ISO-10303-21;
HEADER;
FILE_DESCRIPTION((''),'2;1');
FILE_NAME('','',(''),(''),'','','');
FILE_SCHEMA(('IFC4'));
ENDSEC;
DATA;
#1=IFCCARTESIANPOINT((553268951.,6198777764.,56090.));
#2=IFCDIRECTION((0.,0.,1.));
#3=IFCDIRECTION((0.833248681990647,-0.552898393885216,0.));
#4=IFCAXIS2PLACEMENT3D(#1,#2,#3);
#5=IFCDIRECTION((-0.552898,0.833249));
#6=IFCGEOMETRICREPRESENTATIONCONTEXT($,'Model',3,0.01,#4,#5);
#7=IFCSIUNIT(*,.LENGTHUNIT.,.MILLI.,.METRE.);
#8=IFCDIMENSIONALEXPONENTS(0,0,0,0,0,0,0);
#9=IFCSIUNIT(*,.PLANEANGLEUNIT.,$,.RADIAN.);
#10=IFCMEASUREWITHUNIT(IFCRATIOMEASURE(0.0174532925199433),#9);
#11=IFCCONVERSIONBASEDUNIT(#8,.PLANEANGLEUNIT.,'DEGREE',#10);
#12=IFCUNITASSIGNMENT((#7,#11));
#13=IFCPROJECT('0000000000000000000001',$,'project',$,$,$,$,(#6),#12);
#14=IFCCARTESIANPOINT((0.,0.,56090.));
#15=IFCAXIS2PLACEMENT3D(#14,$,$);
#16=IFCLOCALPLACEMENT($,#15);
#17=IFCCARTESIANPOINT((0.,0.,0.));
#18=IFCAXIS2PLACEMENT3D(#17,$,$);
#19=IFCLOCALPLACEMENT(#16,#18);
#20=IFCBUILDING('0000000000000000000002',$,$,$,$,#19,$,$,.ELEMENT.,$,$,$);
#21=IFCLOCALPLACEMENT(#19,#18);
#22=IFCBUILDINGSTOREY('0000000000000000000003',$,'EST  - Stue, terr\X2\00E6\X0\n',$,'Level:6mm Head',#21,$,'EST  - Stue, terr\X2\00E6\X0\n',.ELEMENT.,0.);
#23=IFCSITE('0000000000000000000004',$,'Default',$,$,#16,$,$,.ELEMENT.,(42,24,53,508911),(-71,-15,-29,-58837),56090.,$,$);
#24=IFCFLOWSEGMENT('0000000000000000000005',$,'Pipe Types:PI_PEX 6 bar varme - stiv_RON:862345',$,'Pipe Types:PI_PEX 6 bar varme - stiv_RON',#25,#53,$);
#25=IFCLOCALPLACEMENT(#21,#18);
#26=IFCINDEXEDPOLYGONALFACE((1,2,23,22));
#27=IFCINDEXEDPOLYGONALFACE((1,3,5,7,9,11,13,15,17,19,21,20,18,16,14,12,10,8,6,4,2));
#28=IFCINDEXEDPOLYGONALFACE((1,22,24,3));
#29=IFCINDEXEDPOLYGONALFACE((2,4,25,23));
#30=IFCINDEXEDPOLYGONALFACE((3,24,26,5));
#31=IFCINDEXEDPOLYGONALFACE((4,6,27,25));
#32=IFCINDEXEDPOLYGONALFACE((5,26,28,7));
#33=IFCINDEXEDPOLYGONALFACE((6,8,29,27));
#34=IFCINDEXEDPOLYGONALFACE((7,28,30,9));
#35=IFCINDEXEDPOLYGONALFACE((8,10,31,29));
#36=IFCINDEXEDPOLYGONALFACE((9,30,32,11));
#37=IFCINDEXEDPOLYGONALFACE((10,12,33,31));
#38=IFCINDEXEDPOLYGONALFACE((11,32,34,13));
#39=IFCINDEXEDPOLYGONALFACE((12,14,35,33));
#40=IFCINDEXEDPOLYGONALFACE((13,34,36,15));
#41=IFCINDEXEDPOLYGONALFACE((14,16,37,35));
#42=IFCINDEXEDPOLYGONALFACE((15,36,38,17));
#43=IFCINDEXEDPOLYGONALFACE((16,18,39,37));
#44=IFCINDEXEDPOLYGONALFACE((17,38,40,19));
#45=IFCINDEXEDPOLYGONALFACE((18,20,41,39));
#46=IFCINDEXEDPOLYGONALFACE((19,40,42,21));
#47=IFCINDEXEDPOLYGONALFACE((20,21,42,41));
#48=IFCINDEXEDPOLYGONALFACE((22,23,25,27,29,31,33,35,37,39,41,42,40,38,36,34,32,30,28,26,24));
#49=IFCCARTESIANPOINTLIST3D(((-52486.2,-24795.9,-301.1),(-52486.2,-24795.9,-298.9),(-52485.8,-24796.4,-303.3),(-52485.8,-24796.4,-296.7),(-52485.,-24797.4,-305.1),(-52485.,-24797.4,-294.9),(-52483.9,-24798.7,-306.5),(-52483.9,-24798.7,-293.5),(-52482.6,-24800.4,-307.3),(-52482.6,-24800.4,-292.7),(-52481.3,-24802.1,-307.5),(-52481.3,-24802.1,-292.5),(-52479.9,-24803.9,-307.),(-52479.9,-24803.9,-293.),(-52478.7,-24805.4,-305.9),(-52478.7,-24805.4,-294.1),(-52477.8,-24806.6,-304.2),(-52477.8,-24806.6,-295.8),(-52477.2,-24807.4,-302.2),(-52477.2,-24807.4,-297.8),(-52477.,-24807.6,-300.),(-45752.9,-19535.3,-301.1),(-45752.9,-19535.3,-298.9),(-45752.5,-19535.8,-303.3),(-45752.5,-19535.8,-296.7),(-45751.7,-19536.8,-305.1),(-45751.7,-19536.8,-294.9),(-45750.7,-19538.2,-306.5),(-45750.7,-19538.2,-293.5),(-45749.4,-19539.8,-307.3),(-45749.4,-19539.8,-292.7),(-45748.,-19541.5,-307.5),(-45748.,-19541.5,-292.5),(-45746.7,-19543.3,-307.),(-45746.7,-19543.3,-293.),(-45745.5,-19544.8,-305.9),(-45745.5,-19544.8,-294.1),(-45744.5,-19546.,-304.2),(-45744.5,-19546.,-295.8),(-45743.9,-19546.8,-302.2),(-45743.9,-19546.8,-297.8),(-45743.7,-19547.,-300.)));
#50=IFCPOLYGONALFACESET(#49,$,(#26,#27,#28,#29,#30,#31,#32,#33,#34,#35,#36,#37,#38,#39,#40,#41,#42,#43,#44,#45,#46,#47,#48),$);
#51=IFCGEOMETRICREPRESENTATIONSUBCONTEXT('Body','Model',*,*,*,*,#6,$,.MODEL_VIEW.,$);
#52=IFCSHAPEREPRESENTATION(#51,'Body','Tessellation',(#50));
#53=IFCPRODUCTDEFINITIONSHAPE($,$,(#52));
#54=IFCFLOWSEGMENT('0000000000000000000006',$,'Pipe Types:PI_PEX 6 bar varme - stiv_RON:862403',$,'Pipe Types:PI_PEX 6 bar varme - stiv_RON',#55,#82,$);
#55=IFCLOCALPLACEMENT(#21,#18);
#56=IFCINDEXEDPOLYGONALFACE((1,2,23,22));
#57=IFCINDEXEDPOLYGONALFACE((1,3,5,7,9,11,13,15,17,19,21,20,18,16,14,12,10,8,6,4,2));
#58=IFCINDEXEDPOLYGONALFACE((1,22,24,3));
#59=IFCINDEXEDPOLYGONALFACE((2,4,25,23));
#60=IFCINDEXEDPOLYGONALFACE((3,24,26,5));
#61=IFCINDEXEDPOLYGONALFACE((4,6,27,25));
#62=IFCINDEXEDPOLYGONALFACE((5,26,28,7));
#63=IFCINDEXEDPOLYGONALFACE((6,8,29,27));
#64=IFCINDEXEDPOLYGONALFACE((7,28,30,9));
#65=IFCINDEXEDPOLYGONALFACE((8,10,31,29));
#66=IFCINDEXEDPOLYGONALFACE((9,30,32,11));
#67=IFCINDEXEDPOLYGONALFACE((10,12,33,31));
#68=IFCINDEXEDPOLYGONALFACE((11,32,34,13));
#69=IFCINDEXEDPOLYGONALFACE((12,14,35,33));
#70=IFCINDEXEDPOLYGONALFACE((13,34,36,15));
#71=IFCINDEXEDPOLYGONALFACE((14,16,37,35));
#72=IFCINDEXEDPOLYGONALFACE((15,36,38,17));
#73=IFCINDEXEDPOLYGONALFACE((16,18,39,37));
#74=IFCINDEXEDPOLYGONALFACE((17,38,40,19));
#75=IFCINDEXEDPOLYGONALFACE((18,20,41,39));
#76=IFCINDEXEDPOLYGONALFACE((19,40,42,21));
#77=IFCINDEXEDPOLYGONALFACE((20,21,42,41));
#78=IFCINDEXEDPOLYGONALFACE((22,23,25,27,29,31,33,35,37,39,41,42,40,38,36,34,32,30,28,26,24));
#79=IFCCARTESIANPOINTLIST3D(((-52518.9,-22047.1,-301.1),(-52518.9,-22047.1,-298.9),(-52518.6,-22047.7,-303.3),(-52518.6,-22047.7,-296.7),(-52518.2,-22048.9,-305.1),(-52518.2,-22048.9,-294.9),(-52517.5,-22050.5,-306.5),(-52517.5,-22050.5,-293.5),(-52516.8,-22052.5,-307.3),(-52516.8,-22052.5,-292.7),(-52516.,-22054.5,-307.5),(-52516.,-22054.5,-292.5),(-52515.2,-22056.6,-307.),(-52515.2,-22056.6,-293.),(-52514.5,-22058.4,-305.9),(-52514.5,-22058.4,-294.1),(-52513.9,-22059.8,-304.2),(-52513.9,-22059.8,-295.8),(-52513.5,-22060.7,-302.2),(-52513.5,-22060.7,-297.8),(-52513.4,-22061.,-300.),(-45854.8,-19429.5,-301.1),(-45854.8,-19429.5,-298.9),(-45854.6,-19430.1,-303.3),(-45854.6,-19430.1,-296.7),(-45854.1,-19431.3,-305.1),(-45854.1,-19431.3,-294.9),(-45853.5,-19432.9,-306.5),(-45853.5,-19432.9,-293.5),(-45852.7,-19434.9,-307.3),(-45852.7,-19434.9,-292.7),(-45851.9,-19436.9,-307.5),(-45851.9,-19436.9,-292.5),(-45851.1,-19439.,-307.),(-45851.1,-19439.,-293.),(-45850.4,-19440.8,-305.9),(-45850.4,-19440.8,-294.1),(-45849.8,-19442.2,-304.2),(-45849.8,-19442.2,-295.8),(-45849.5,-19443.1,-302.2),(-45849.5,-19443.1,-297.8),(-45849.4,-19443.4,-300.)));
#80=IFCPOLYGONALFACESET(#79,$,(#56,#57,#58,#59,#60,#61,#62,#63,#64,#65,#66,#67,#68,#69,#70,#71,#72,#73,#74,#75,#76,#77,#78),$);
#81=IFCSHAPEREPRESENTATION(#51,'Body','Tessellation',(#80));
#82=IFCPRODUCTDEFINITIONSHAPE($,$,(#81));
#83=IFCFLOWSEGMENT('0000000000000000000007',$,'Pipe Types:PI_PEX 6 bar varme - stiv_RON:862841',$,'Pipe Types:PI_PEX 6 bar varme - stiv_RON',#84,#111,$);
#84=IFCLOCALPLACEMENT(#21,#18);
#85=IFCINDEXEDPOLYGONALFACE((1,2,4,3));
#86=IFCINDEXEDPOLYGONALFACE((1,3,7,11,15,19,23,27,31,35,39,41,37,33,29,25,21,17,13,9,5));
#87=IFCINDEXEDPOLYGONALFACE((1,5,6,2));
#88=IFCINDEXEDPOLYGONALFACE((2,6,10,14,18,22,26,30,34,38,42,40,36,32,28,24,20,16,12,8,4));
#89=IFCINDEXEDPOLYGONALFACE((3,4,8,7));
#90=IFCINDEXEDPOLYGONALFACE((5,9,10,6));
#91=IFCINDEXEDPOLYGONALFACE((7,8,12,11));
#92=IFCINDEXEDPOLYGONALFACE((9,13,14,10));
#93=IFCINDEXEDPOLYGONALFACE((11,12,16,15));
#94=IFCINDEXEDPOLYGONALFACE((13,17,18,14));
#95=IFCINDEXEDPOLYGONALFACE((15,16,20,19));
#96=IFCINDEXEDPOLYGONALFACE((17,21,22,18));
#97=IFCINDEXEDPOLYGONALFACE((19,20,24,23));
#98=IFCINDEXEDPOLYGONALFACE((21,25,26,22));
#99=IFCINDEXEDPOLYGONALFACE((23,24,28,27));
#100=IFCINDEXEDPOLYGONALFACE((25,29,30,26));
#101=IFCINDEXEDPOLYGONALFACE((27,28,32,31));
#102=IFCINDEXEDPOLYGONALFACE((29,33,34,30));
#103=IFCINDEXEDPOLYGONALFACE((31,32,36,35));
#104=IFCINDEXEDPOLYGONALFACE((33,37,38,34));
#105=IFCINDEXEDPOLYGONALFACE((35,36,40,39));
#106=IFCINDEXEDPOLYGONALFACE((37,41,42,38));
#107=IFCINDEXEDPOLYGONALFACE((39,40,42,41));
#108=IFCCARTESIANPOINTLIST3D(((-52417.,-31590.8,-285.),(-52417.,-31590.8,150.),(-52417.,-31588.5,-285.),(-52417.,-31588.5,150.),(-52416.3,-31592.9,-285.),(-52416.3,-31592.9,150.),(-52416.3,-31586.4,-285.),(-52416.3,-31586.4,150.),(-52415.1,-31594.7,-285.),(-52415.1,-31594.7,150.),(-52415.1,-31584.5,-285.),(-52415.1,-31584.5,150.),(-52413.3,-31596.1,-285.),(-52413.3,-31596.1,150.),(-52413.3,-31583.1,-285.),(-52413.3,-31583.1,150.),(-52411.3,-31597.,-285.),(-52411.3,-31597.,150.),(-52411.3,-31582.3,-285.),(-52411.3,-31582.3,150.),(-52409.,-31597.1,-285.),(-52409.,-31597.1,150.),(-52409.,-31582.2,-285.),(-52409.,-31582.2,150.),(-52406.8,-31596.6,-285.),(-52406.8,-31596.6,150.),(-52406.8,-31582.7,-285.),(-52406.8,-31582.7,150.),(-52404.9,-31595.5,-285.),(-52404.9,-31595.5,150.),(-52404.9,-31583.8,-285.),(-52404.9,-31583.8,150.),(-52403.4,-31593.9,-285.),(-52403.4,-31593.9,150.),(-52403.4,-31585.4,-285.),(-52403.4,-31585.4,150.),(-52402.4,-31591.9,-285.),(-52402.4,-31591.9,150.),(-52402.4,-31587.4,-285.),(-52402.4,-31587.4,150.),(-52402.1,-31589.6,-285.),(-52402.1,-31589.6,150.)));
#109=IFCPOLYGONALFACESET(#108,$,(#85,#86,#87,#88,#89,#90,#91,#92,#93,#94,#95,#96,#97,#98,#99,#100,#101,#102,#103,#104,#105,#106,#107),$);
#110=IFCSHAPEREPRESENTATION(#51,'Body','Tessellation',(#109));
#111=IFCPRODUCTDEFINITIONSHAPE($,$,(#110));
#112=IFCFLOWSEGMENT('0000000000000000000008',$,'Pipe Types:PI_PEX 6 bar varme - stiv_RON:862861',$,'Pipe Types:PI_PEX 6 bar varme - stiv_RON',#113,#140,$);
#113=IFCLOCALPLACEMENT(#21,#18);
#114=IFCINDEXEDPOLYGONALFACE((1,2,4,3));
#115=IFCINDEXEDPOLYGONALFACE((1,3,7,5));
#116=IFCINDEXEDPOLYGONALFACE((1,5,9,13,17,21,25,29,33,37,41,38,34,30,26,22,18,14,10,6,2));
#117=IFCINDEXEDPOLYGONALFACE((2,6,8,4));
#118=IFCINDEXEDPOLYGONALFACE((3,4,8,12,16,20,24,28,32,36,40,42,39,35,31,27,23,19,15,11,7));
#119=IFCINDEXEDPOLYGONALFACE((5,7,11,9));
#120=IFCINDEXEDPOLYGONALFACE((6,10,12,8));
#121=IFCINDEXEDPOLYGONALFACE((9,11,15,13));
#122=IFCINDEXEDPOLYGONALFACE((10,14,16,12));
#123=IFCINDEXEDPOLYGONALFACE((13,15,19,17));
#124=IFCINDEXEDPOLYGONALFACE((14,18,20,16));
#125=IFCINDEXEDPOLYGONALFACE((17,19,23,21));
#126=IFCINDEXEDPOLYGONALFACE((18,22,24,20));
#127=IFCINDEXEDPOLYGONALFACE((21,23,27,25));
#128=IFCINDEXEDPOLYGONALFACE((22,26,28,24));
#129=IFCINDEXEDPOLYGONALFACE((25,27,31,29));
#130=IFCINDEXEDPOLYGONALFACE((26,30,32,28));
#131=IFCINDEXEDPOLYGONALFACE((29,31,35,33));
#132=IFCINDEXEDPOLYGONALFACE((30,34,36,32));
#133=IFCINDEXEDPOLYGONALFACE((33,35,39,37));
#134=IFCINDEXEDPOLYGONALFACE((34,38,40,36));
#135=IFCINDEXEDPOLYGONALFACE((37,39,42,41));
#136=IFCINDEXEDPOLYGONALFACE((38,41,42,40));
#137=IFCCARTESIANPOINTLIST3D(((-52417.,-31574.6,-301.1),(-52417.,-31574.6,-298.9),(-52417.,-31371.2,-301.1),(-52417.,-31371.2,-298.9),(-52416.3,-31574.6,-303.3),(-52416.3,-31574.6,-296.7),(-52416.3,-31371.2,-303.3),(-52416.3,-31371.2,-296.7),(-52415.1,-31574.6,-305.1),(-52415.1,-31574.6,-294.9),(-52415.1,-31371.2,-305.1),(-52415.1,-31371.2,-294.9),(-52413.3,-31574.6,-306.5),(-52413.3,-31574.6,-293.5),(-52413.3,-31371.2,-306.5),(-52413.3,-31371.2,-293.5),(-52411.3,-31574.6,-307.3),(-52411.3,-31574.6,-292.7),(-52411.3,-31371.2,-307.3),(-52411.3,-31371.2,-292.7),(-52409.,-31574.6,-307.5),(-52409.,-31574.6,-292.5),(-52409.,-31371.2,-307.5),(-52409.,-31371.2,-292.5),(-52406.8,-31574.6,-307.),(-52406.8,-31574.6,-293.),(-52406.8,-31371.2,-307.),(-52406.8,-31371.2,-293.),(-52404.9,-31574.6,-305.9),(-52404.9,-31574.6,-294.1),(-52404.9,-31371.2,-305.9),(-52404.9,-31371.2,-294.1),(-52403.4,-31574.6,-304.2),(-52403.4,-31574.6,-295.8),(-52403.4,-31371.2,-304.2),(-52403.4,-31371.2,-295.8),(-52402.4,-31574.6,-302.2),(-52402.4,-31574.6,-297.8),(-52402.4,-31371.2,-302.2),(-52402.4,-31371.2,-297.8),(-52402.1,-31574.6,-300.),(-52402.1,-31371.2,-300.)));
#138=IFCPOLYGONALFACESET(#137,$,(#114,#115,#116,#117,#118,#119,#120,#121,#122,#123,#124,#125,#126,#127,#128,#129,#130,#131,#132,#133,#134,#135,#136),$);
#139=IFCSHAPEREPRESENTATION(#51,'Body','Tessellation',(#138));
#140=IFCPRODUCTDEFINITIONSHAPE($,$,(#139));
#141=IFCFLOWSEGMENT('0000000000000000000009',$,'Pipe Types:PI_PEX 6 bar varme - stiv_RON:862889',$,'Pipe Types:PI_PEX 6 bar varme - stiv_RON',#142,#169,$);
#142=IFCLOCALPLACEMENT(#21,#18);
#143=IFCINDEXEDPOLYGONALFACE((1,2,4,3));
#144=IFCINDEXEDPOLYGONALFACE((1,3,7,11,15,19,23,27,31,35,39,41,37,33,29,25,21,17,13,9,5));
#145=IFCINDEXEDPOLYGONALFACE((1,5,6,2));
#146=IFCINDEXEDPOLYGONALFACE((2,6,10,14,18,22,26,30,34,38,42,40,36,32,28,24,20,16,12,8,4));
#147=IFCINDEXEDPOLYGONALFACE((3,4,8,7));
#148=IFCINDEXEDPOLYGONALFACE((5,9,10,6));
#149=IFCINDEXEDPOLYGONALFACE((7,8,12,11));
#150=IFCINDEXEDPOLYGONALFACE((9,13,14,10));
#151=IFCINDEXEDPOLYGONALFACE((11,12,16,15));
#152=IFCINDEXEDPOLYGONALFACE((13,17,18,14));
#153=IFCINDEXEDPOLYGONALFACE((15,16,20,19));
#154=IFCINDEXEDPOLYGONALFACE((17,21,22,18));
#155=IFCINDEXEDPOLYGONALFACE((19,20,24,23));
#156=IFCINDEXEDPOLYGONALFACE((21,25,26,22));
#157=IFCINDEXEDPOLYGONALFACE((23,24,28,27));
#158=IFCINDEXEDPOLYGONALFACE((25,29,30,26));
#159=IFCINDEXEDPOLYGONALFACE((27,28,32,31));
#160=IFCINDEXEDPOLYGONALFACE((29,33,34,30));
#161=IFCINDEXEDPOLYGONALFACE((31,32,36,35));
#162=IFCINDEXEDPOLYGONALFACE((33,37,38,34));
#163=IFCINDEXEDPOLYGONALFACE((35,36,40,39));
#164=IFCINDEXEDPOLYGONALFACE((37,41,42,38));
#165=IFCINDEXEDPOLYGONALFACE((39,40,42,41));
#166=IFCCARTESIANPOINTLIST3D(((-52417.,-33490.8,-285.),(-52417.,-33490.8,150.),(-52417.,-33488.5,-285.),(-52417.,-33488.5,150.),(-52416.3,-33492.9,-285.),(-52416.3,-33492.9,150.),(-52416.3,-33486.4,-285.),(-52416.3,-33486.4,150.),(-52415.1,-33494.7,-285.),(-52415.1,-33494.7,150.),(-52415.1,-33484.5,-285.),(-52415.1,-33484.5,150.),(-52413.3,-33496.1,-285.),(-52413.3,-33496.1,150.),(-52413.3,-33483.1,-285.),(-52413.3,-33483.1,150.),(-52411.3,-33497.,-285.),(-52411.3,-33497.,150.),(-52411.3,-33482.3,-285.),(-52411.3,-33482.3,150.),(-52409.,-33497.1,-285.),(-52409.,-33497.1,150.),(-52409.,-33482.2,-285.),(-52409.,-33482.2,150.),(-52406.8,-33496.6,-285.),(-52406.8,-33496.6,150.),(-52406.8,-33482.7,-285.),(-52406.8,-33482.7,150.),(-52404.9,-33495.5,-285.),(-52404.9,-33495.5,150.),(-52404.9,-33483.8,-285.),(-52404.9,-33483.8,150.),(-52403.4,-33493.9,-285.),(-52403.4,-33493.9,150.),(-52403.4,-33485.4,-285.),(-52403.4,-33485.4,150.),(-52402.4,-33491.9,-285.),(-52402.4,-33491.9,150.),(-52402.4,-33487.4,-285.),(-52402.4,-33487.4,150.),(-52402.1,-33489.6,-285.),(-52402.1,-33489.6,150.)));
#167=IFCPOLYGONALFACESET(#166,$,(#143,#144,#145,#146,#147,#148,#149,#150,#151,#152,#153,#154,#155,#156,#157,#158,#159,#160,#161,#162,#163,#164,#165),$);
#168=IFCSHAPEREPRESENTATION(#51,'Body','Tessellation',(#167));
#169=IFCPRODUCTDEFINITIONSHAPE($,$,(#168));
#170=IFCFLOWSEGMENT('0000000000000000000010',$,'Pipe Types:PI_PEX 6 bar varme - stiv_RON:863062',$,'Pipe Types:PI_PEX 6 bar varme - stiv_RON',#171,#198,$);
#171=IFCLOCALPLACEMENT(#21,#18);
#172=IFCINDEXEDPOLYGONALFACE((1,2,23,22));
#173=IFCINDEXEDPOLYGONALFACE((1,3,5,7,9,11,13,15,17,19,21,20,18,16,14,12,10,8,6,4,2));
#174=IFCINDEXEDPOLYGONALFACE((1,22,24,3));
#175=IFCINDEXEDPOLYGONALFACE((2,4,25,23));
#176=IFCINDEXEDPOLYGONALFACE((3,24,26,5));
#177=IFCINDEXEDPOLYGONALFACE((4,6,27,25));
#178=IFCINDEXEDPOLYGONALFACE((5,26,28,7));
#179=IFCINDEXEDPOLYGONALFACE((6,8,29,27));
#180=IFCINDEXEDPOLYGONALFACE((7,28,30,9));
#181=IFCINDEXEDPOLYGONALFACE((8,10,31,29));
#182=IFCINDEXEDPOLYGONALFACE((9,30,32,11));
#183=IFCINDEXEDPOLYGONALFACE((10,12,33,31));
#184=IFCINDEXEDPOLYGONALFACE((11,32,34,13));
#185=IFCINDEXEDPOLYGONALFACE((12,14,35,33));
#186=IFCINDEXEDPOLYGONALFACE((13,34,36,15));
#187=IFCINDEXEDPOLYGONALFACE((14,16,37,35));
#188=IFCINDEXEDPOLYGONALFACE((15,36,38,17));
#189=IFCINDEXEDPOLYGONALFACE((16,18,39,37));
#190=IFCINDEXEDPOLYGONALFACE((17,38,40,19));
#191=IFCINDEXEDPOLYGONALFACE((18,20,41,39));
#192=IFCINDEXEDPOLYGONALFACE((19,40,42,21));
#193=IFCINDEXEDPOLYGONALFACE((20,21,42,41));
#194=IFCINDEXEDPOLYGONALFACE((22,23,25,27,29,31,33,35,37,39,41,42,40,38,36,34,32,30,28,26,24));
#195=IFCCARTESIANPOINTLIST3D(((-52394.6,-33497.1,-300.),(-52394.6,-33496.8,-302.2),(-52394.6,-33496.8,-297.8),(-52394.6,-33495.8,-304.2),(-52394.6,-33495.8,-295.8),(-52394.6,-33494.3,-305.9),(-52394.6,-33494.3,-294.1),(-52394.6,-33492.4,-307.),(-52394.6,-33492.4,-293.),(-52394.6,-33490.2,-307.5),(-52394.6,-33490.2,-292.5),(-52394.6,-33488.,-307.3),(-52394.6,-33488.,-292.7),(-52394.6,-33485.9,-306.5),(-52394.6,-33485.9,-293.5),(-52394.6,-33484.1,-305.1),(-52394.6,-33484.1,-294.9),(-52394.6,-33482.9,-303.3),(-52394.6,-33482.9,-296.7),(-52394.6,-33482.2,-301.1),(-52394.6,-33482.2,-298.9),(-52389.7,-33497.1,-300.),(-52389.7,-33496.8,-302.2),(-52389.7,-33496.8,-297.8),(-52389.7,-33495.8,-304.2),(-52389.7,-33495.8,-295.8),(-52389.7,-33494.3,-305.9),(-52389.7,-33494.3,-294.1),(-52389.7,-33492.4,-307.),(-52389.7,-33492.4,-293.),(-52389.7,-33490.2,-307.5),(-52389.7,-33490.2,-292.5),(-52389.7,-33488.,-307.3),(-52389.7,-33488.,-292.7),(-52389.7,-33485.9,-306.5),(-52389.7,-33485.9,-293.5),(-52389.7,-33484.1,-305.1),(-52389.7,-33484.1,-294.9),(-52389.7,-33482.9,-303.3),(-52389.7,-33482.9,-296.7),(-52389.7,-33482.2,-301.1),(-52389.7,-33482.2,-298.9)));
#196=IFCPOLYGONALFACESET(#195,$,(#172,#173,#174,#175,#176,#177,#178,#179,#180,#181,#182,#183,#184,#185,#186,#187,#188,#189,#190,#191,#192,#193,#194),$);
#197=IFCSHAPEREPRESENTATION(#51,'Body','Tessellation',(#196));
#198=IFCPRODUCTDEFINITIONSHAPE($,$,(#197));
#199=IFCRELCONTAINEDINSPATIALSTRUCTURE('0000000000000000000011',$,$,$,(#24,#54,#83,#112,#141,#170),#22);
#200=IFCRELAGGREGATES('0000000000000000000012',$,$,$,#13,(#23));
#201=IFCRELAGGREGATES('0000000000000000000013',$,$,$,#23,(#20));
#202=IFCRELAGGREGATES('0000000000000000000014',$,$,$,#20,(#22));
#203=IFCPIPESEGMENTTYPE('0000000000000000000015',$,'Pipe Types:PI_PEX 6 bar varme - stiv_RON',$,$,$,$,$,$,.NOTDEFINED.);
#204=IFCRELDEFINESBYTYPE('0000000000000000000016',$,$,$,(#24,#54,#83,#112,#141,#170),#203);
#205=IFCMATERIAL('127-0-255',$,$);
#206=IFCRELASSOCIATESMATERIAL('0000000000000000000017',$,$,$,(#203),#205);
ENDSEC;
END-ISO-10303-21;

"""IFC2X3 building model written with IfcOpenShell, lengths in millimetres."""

from ifc_helpers import new_model, entity, si_unit, converted_unit, direction, frame, frame_2d, origin, origin_2d_with_axis, place, context, subcontext, project, spatial, circle, extrude, material, type_object, element, save


model = new_model("IFC2X3")

# Units and contexts
model_context = context("Model", 3, precision=0.01, world=frame((553268951.0, 6198777764.0, 56090.0), z_axis=(0.0, 0.0, 1.0), x_axis=(0.833248681990647, -0.552898393885216, 0.0)), true_north=direction((-0.552898, 0.833249)))
body_context = subcontext(model_context, "Body", "Model", "MODEL_VIEW")
ifc_project = project(units=[si_unit("LENGTHUNIT", "METRE", prefix="MILLI"), converted_unit("PLANEANGLEUNIT", "DEGREE", entity("IfcRatioMeasure", 0.0174532925199433), si_unit("PLANEANGLEUNIT", "RADIAN"), dimensions=[0, 0, 0, 0, 0, 0, 0])], contexts=[model_context])

# Site, building, storey
site_placement = place(None, frame((0.0, 0.0, 56090.0)))
site = spatial("IfcSite", under=ifc_project, at=site_placement, Name="Default", CompositionType="ELEMENT", RefLatitude=(42, 24, 53, 508911), RefLongitude=(-71, -15, -29, -58837), RefElevation=56090.0)
building_placement = place(site_placement, origin())
building = spatial("IfcBuilding", under=site, at=building_placement, CompositionType="ELEMENT")
storey_placement = place(building_placement, frame((0.0, 0.0, 0.0)))
storey = spatial("IfcBuildingStorey", under=building, at=storey_placement, Name="EST  - Stue, terræn", ObjectType="Level:6mm Head", LongName="EST  - Stue, terræn", CompositionType="ELEMENT", Elevation=0.0)

# Flow segments
ifc_material_1 = material(Name="127-0-255")
pipe_segment_type_1 = type_object("IfcPipeSegmentType", Name="Pipe Types:PI_PEX 6 bar varme - stiv_RON", PredefinedType="NOTDEFINED", material=ifc_material_1)
flow_segment_1_placement = place(storey_placement, origin())
element("IfcFlowSegment", 1, at=flow_segment_1_placement, inside=storey, type_object=pipe_segment_type_1, Name="Pipe Types:PI_PEX 6 bar varme - stiv_RON:862345", ObjectType="Pipe Types:PI_PEX 6 bar varme - stiv_RON", context=body_context, shape_type="SweptSolid", body=[
    extrude(circle(Radius=7.5, at=origin_2d_with_axis()), frame((-52481.6, -24801.7, -300.0), z_axis=(0.788011, 0.615661, 0.0), x_axis=(0.615661, -0.788011, 0.0)), (0.0, 0.0, 1.0), 8544.6),
])
flow_segment_2_placement = place(storey_placement, origin())
element("IfcFlowSegment", 2, at=flow_segment_2_placement, inside=storey, type_object=pipe_segment_type_1, Name="Pipe Types:PI_PEX 6 bar varme - stiv_RON:862403", ObjectType="Pipe Types:PI_PEX 6 bar varme - stiv_RON", context=body_context, shape_type="SweptSolid", body=[
    extrude(circle(Radius=7.5, at=frame_2d((0.0, 0.0), x_axis=(1.0, 0.0))), frame((-52516.2, -22054.0, -300.0), z_axis=(0.930772, 0.365601, 0.0), x_axis=(0.365601, -0.930772, 0.0)), (0.0, 0.0, 1.0), 7159.7),
])
flow_segment_3_placement = place(storey_placement, origin())
element("IfcFlowSegment", 3, at=flow_segment_3_placement, inside=storey, type_object=pipe_segment_type_1, Name="Pipe Types:PI_PEX 6 bar varme - stiv_RON:862841", ObjectType="Pipe Types:PI_PEX 6 bar varme - stiv_RON", context=body_context, shape_type="SweptSolid", body=[
    extrude(circle(Radius=7.5, at=origin_2d_with_axis()), frame((-52409.6, -31589.6, -285.0)), (0.0, 0.0, 1.0), 435.0),
])
flow_segment_4_placement = place(storey_placement, origin())
element("IfcFlowSegment", 4, at=flow_segment_4_placement, inside=storey, type_object=pipe_segment_type_1, Name="Pipe Types:PI_PEX 6 bar varme - stiv_RON:862861", ObjectType="Pipe Types:PI_PEX 6 bar varme - stiv_RON", context=body_context, shape_type="SweptSolid", body=[
    extrude(circle(Radius=7.5, at=origin_2d_with_axis()), frame((-52409.6, -31574.6, -300.0), z_axis=(0.0, 1.0, 0.0), x_axis=(1.0, 0.0, 0.0)), (0.0, 0.0, 1.0), 203.4),
])
flow_segment_5_placement = place(storey_placement, origin())
element("IfcFlowSegment", 5, at=flow_segment_5_placement, inside=storey, type_object=pipe_segment_type_1, Name="Pipe Types:PI_PEX 6 bar varme - stiv_RON:862889", ObjectType="Pipe Types:PI_PEX 6 bar varme - stiv_RON", context=body_context, shape_type="SweptSolid", body=[
    extrude(circle(Radius=7.5, at=origin_2d_with_axis()), frame((-52409.6, -33489.6, -285.0)), (0.0, 0.0, 1.0), 435.0),
])
flow_segment_6_placement = place(storey_placement, origin())
element("IfcFlowSegment", 6, at=flow_segment_6_placement, inside=storey, type_object=pipe_segment_type_1, Name="Pipe Types:PI_PEX 6 bar varme - stiv_RON:863062", ObjectType="Pipe Types:PI_PEX 6 bar varme - stiv_RON", context=body_context, shape_type="SweptSolid", body=[
    extrude(circle(Radius=7.5, at=origin_2d_with_axis()), frame((-52394.6, -33489.6, -300.0), z_axis=(1.0, 0.0, 0.0), x_axis=(0.0, -1.0, 0.0)), (0.0, 0.0, 1.0), 4.9),
])

save(model, "model.ifc")
